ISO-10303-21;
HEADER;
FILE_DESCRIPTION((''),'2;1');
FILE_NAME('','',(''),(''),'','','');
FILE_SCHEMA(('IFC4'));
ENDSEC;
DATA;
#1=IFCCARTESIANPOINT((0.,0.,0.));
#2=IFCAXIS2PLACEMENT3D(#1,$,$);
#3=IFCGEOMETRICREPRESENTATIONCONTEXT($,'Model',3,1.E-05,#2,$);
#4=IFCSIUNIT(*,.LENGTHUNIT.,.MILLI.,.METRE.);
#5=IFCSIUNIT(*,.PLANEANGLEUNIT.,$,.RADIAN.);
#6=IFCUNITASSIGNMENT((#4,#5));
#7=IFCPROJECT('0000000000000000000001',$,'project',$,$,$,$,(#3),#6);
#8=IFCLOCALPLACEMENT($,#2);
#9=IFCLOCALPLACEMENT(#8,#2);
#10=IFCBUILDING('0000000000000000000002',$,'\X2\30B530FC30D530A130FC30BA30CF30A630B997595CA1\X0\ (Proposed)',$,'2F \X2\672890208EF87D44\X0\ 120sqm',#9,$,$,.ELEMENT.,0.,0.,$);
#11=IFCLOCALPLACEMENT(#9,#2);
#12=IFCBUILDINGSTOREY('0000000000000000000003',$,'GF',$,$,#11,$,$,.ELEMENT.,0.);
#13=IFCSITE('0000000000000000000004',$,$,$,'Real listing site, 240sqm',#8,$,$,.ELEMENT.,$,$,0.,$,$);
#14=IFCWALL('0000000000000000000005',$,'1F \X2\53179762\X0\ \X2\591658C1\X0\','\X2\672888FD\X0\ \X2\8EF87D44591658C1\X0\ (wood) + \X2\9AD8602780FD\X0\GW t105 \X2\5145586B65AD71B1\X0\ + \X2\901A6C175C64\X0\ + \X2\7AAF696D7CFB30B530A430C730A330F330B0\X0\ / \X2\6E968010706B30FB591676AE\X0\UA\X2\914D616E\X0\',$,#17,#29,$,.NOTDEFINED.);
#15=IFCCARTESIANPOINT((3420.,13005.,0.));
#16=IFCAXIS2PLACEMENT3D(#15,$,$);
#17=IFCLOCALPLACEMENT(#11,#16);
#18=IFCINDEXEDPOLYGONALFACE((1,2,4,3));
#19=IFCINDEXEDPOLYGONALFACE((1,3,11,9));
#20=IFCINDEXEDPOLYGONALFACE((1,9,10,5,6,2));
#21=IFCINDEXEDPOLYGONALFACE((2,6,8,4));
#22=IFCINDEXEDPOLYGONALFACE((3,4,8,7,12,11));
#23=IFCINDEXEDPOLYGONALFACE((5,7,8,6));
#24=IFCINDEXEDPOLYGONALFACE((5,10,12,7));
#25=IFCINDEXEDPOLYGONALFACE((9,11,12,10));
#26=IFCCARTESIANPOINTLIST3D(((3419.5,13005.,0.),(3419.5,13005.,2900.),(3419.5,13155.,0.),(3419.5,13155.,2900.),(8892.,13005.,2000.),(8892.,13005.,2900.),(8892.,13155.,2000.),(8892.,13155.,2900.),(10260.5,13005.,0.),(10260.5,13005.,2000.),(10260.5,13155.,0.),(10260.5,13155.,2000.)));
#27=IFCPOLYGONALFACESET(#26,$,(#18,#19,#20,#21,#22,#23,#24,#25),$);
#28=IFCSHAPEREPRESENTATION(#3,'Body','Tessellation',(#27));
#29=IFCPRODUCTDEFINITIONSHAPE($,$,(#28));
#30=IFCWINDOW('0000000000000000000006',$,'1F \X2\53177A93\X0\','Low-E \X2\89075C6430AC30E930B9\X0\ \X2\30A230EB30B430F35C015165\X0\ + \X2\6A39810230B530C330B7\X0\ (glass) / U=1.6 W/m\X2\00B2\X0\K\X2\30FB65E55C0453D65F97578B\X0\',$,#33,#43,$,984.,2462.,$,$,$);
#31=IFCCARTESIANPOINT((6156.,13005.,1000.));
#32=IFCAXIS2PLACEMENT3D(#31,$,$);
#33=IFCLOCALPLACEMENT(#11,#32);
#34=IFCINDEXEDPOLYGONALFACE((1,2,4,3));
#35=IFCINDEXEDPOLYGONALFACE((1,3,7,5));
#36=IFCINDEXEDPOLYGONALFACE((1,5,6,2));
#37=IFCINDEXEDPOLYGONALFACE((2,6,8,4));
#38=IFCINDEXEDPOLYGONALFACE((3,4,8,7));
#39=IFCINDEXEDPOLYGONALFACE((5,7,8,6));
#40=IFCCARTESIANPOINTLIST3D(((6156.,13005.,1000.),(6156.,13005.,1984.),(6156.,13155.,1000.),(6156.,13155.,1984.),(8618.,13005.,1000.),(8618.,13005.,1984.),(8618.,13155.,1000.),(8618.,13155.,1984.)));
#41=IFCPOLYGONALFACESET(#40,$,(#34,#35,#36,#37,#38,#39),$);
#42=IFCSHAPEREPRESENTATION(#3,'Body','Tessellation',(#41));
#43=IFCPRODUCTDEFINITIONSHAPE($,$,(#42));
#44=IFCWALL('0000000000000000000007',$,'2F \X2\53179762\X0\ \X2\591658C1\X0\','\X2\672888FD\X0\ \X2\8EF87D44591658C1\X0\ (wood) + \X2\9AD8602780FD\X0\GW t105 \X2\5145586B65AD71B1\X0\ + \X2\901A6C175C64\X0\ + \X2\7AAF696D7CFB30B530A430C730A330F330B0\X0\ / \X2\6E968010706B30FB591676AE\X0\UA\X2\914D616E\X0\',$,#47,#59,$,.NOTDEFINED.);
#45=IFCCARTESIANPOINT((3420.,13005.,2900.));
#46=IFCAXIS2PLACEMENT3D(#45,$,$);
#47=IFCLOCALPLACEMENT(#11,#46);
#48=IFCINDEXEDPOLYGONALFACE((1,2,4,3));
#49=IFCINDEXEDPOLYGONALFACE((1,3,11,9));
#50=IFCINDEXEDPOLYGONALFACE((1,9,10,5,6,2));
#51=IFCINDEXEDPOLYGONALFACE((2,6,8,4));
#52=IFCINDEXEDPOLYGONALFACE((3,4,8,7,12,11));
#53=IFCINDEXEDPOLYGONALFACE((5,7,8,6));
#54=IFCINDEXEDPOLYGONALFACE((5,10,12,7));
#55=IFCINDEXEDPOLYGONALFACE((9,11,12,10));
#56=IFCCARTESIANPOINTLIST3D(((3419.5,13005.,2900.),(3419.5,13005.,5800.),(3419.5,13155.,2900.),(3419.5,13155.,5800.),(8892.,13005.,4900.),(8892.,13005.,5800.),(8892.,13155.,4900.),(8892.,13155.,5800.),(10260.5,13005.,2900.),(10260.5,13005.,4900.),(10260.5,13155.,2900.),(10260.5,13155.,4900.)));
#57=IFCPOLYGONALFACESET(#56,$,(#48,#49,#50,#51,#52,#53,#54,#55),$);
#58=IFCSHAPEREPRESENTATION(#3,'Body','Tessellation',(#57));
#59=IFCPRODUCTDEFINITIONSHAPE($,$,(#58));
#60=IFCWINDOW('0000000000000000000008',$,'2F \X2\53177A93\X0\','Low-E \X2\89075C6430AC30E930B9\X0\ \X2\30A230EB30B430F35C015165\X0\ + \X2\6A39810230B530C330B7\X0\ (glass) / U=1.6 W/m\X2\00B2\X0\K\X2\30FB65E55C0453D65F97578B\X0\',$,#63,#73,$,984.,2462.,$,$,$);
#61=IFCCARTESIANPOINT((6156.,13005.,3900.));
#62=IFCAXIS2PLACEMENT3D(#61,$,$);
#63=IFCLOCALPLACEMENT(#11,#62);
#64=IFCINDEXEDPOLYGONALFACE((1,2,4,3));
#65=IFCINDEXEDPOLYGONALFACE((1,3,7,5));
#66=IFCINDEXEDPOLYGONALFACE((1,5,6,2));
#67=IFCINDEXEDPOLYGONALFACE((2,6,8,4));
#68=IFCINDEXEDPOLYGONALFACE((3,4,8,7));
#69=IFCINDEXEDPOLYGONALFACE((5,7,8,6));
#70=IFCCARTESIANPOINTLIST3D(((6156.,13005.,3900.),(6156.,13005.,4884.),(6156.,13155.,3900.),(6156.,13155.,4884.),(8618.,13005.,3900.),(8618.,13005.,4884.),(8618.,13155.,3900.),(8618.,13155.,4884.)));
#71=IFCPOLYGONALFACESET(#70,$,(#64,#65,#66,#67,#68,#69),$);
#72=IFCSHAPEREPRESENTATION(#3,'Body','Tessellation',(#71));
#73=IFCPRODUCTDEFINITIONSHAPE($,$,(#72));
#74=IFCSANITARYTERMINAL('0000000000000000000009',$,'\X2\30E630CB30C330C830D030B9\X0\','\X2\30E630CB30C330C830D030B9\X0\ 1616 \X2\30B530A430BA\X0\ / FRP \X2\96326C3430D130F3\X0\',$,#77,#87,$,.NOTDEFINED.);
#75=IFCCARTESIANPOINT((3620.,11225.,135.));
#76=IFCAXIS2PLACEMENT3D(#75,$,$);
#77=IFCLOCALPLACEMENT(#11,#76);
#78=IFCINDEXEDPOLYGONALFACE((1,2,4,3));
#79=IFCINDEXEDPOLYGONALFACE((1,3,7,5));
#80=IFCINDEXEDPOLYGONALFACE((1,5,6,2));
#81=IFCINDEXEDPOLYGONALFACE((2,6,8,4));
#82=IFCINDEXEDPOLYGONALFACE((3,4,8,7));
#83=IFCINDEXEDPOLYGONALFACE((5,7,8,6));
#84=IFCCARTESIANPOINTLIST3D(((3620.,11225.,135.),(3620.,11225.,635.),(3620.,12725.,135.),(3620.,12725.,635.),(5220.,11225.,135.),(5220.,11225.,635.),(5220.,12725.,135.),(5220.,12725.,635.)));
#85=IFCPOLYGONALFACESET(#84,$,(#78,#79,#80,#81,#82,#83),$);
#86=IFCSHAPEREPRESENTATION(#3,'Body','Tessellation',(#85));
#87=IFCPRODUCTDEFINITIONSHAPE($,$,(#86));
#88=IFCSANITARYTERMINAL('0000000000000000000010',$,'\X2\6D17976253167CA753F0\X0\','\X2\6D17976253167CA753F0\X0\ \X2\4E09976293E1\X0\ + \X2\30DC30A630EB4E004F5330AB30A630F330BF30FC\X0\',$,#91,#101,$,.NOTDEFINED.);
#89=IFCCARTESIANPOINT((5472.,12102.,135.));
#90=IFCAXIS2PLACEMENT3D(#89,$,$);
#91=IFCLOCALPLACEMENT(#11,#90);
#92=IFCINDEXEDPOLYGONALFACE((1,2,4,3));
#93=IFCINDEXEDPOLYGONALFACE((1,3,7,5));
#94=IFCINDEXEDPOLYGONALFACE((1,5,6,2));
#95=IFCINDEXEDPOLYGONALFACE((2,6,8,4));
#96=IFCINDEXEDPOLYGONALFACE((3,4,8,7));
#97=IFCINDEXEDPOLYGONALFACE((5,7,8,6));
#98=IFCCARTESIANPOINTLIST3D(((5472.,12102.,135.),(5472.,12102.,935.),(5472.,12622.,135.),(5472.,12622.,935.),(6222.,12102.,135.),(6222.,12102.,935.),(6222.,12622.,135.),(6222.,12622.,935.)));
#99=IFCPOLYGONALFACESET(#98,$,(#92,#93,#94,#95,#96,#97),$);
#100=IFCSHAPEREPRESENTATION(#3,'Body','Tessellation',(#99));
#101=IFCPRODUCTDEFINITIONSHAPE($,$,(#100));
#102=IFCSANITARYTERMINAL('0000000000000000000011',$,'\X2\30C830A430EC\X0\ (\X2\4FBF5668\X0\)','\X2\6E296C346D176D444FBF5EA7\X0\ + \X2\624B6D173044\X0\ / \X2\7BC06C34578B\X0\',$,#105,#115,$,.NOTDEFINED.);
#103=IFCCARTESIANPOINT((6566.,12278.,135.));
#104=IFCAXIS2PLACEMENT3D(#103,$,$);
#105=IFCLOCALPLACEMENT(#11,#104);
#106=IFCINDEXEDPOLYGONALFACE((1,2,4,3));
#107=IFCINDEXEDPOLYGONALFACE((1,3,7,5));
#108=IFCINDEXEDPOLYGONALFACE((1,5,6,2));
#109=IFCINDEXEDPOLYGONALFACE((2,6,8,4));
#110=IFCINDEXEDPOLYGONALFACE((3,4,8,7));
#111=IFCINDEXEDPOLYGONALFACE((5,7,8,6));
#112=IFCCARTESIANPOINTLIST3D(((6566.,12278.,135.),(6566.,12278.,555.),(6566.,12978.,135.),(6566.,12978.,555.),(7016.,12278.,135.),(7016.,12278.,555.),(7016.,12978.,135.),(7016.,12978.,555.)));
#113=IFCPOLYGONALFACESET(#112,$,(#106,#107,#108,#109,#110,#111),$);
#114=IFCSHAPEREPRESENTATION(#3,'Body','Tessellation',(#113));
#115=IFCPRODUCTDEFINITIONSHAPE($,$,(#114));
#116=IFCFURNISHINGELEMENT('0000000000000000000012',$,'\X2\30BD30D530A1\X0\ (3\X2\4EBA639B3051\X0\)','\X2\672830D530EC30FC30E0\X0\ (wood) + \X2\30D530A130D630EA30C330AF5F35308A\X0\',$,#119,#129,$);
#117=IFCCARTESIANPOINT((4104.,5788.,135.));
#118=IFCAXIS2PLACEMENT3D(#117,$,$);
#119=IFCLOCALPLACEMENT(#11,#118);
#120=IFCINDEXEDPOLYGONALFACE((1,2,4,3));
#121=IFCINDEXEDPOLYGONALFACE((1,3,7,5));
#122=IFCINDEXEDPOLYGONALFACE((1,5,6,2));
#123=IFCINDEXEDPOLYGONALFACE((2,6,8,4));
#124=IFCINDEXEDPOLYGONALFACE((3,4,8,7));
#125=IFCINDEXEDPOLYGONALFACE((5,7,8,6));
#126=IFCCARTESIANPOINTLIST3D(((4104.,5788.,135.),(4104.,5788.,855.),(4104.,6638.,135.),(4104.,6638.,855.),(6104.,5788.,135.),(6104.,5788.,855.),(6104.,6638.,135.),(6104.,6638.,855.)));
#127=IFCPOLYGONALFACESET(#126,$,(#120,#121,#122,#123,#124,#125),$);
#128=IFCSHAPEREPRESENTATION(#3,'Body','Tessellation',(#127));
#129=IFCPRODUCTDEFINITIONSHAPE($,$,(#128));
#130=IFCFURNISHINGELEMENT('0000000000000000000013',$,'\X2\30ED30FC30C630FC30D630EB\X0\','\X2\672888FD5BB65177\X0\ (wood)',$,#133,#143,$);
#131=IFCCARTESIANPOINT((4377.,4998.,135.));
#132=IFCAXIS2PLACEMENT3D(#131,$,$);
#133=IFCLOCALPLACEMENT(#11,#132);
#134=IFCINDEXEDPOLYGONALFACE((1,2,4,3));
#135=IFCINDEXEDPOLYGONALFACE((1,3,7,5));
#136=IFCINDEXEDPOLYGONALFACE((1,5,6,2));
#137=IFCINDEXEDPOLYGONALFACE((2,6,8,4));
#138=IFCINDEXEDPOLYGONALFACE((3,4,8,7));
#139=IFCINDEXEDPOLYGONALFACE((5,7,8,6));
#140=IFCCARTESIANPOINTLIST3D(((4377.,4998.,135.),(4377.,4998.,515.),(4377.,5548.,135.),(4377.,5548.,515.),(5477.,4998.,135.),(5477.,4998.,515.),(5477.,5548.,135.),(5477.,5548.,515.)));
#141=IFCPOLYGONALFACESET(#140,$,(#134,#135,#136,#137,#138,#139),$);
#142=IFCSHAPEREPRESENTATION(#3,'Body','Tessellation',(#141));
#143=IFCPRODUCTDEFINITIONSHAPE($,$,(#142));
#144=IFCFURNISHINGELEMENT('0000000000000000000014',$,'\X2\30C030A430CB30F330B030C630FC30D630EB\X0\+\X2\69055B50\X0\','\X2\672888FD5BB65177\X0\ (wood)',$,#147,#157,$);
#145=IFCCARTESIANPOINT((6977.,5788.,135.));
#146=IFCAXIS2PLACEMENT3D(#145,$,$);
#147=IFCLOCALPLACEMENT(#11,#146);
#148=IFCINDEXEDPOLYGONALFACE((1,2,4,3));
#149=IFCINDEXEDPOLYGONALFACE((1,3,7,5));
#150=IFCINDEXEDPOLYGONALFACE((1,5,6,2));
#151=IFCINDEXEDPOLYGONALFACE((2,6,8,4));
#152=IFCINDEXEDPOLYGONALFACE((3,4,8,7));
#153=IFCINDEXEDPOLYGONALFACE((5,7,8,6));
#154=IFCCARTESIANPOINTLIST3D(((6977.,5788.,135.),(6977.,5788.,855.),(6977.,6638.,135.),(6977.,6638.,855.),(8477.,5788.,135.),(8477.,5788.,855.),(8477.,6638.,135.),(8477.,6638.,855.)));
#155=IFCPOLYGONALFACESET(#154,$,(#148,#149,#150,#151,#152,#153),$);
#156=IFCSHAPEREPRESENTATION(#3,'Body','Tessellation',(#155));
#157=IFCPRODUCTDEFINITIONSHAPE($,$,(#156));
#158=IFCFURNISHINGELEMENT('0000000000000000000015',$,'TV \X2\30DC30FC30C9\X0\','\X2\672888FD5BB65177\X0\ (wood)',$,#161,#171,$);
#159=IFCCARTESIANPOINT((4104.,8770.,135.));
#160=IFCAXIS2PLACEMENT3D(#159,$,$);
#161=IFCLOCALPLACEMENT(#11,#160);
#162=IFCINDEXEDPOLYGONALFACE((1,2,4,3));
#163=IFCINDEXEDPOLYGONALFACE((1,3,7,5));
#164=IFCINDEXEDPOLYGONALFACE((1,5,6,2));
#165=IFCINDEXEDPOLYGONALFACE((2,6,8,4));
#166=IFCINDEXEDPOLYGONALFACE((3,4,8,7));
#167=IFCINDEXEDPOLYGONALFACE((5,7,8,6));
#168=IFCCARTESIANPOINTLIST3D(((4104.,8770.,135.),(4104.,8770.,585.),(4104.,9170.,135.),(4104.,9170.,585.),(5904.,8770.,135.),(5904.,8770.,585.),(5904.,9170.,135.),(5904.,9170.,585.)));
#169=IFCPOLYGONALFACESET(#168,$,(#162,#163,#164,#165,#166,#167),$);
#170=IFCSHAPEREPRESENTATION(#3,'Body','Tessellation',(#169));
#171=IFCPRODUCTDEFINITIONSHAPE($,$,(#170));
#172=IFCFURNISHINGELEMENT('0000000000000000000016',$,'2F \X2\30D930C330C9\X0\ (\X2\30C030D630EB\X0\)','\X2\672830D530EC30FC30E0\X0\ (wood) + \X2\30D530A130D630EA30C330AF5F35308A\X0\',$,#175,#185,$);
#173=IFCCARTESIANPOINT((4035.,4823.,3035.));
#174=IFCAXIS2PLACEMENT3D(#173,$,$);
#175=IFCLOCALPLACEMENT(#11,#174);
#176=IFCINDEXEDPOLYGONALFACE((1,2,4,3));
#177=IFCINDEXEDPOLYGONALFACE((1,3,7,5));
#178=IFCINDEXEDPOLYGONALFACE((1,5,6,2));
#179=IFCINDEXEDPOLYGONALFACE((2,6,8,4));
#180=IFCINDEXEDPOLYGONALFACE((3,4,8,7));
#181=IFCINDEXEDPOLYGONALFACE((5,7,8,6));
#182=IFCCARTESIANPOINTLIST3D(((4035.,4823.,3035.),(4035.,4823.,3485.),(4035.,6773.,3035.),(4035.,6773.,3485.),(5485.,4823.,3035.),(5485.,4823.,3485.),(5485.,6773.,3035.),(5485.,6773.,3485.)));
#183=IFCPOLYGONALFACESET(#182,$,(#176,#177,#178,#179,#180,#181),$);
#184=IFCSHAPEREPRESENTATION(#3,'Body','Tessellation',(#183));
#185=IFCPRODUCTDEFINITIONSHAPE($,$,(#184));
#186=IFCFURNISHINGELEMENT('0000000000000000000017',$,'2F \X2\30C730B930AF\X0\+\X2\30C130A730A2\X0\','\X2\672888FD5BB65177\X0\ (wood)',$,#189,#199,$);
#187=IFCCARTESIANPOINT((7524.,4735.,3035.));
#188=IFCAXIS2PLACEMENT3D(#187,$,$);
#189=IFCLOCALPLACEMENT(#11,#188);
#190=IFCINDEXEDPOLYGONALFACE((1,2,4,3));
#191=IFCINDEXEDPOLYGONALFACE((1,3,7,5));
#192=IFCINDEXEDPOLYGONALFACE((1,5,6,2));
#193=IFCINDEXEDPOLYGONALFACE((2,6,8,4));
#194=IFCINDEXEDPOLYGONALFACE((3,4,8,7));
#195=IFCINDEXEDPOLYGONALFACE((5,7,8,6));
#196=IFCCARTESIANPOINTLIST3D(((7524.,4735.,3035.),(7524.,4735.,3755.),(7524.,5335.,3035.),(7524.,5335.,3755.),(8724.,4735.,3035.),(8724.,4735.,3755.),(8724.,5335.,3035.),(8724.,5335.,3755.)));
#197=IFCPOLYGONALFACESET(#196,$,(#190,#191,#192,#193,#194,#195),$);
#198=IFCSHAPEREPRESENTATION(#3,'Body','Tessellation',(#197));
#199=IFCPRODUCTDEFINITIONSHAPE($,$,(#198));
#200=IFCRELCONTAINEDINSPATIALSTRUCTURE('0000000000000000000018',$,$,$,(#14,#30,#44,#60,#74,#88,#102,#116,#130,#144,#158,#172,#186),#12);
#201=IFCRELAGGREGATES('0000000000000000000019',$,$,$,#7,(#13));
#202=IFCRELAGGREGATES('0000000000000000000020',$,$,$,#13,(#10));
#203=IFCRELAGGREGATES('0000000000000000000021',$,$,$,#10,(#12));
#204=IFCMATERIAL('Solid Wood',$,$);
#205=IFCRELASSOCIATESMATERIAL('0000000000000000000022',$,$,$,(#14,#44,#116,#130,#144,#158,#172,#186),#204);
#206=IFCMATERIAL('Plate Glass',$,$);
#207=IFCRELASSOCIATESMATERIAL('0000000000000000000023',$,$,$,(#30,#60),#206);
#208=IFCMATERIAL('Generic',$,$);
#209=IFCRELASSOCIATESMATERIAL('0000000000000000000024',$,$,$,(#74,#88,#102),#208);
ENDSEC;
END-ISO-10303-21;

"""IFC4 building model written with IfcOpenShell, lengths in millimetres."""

from ifc_helpers import new_model, si_unit, frame, frame_2d, origin, place, context, project, spatial, rectangle, extrude, material, element, fill, save


model = new_model("IFC4")

# Units and contexts
model_context = context("Model", 3, precision=1e-05, world=origin())
ifc_project = project(units=[si_unit("LENGTHUNIT", "METRE", prefix="MILLI"), si_unit("PLANEANGLEUNIT", "RADIAN")], contexts=[model_context])

# Site, building, storey
site_placement = place(None, origin())
site = spatial("IfcSite", under=ifc_project, at=site_placement, ObjectType="Real listing site, 240sqm", CompositionType="ELEMENT", RefElevation=0.0)
building_placement = place(site_placement, origin())
building = spatial("IfcBuilding", under=site, at=building_placement, Name="サーファーズハウス静岡 (Proposed)", ObjectType="2F 木造軸組 120sqm", CompositionType="ELEMENT", ElevationOfRefHeight=0.0, ElevationOfTerrain=0.0)
storey_placement = place(building_placement, origin())
storey = spatial("IfcBuildingStorey", under=building, at=storey_placement, Name="GF", CompositionType="ELEMENT", Elevation=0.0)

# Wall, opening, window
ifc_material_1 = material(Name="Solid Wood")
wall_1_placement = place(storey_placement, frame((3420.0, 13005.0, 0.0)))
wall_1 = element("IfcWall", 1, at=wall_1_placement, inside=storey, material=ifc_material_1, Name="1F 北面 外壁", Description="木製 軸組外壁 (wood) + 高性能GW t105 充填断熱 + 通気層 + 窯業系サイディング / 準耐火・外皮UA配慮", PredefinedType="NOTDEFINED", context=model_context, shape_type="SweptSolid", body=[
    extrude(rectangle(XDim=6841.0, YDim=150.0, at=frame_2d((3420.0, 75.0))), frame((3420.0, 13005.0, 0.0)), (0.0, 0.0, 1.0), 2900.0),
])
opening_1_placement = place(storey_placement, frame((6156.0, 13005.0, 1000.0)))
opening_1 = element("IfcOpeningElement", 2, at=opening_1_placement, cuts=wall_1, PredefinedType="NOTDEFINED", context=model_context, shape_type="SweptSolid", body=[
    extrude(rectangle(XDim=2462.0, YDim=150.0, at=frame_2d((1231.0, 75.0))), frame((6156.0, 13005.0, 1000.0)), (0.0, 0.0, 1.0), 984.0),
])
ifc_material_2 = material(Name="Plate Glass")
window_1_placement = place(storey_placement, frame((6156.0, 13005.0, 1000.0)))
window_1 = element("IfcWindow", 3, at=window_1_placement, inside=storey, material=ifc_material_2, Name="1F 北窓", Description="Low-E 複層ガラス アルゴン封入 + 樹脂サッシ (glass) / U=1.6 W/m²K・日射取得型", OverallHeight=984.0, OverallWidth=2462.0, context=model_context, shape_type="SweptSolid", body=[
    extrude(rectangle(XDim=2462.0, YDim=150.0, at=frame_2d((1231.0, 75.0))), frame((6156.0, 13005.0, 1000.0)), (0.0, 0.0, 1.0), 984.0),
])
fill(opening_1, window_1)

# Wall, opening, window
wall_2_placement = place(storey_placement, frame((3420.0, 13005.0, 2900.0)))
wall_2 = element("IfcWall", 4, at=wall_2_placement, inside=storey, material=ifc_material_1, Name="2F 北面 外壁", Description="木製 軸組外壁 (wood) + 高性能GW t105 充填断熱 + 通気層 + 窯業系サイディング / 準耐火・外皮UA配慮", PredefinedType="NOTDEFINED", context=model_context, shape_type="SweptSolid", body=[
    extrude(rectangle(XDim=6841.0, YDim=150.0, at=frame_2d((3420.0, 75.0))), frame((3420.0, 13005.0, 2900.0)), (0.0, 0.0, 1.0), 2900.0),
])
opening_2_placement = place(storey_placement, frame((6156.0, 13005.0, 3900.0)))
opening_2 = element("IfcOpeningElement", 5, at=opening_2_placement, cuts=wall_2, PredefinedType="NOTDEFINED", context=model_context, shape_type="SweptSolid", body=[
    extrude(rectangle(XDim=2462.0, YDim=150.0, at=frame_2d((1231.0, 75.0))), frame((6156.0, 13005.0, 3900.0)), (0.0, 0.0, 1.0), 984.0),
])
window_2_placement = place(storey_placement, frame((6156.0, 13005.0, 3900.0)))
window_2 = element("IfcWindow", 6, at=window_2_placement, inside=storey, material=ifc_material_2, Name="2F 北窓", Description="Low-E 複層ガラス アルゴン封入 + 樹脂サッシ (glass) / U=1.6 W/m²K・日射取得型", OverallHeight=984.0, OverallWidth=2462.0, context=model_context, shape_type="SweptSolid", body=[
    extrude(rectangle(XDim=2462.0, YDim=150.0, at=frame_2d((1231.0, 75.0))), frame((6156.0, 13005.0, 3900.0)), (0.0, 0.0, 1.0), 984.0),
])
fill(opening_2, window_2)

# Sanitary terminals
ifc_material_3 = material(Name="Generic")
sanitary_terminal_1_placement = place(storey_placement, frame((3620.0, 11225.0, 135.0)))
element("IfcSanitaryTerminal", 7, at=sanitary_terminal_1_placement, inside=storey, material=ifc_material_3, Name="ユニットバス", Description="ユニットバス 1616 サイズ / FRP 防水パン", PredefinedType="NOTDEFINED", context=model_context, shape_type="SweptSolid", body=[
    extrude(rectangle(XDim=1600.0, YDim=1500.0, at=frame_2d((800.0, 750.0))), frame((3620.0, 11225.0, 135.0)), (0.0, 0.0, 1.0), 500.0),
])
sanitary_terminal_2_placement = place(storey_placement, frame((5472.0, 12102.0, 135.0)))
element("IfcSanitaryTerminal", 8, at=sanitary_terminal_2_placement, inside=storey, material=ifc_material_3, Name="洗面化粧台", Description="洗面化粧台 三面鏡 + ボウル一体カウンター", PredefinedType="NOTDEFINED", context=model_context, shape_type="SweptSolid", body=[
    extrude(rectangle(XDim=750.0, YDim=520.0, at=frame_2d((375.0, 260.0))), frame((5472.0, 12102.0, 135.0)), (0.0, 0.0, 1.0), 800.0),
])
sanitary_terminal_3_placement = place(storey_placement, frame((6566.0, 12278.0, 135.0)))
element("IfcSanitaryTerminal", 9, at=sanitary_terminal_3_placement, inside=storey, material=ifc_material_3, Name="トイレ (便器)", Description="温水洗浄便座 + 手洗い / 節水型", PredefinedType="NOTDEFINED", context=model_context, shape_type="SweptSolid", body=[
    extrude(rectangle(XDim=450.0, YDim=700.0, at=frame_2d((225.0, 350.0))), frame((6566.0, 12278.0, 135.0)), (0.0, 0.0, 1.0), 420.0),
])

# Furnishing elements
furnishing_1_placement = place(storey_placement, frame((4104.0, 5788.0, 135.0)))
element("IfcFurnishingElement", 10, at=furnishing_1_placement, inside=storey, material=ifc_material_1, Name="ソファ (3人掛け)", Description="木フレーム (wood) + ファブリック張り", context=model_context, shape_type="SweptSolid", body=[
    extrude(rectangle(XDim=2000.0, YDim=850.0, at=frame_2d((1000.0, 425.0))), frame((4104.0, 5788.0, 135.0)), (0.0, 0.0, 1.0), 720.0),
])
furnishing_2_placement = place(storey_placement, frame((4377.0, 4998.0, 135.0)))
element("IfcFurnishingElement", 11, at=furnishing_2_placement, inside=storey, material=ifc_material_1, Name="ローテーブル", Description="木製家具 (wood)", context=model_context, shape_type="SweptSolid", body=[
    extrude(rectangle(XDim=1100.0, YDim=550.0, at=frame_2d((550.0, 275.0))), frame((4377.0, 4998.0, 135.0)), (0.0, 0.0, 1.0), 380.0),
])
furnishing_3_placement = place(storey_placement, frame((6977.0, 5788.0, 135.0)))
element("IfcFurnishingElement", 12, at=furnishing_3_placement, inside=storey, material=ifc_material_1, Name="ダイニングテーブル+椅子", Description="木製家具 (wood)", context=model_context, shape_type="SweptSolid", body=[
    extrude(rectangle(XDim=1500.0, YDim=850.0, at=frame_2d((750.0, 425.0))), frame((6977.0, 5788.0, 135.0)), (0.0, 0.0, 1.0), 720.0),
])
furnishing_4_placement = place(storey_placement, frame((4104.0, 8770.0, 135.0)))
element("IfcFurnishingElement", 13, at=furnishing_4_placement, inside=storey, material=ifc_material_1, Name="TV ボード", Description="木製家具 (wood)", context=model_context, shape_type="SweptSolid", body=[
    extrude(rectangle(XDim=1800.0, YDim=400.0, at=frame_2d((900.0, 200.0))), frame((4104.0, 8770.0, 135.0)), (0.0, 0.0, 1.0), 450.0),
])
furnishing_5_placement = place(storey_placement, frame((4035.0, 4823.0, 3035.0)))
element("IfcFurnishingElement", 14, at=furnishing_5_placement, inside=storey, material=ifc_material_1, Name="2F ベッド (ダブル)", Description="木フレーム (wood) + ファブリック張り", context=model_context, shape_type="SweptSolid", body=[
    extrude(rectangle(XDim=1450.0, YDim=1950.0, at=frame_2d((725.0, 975.0))), frame((4035.0, 4823.0, 3035.0)), (0.0, 0.0, 1.0), 450.0),
])
furnishing_6_placement = place(storey_placement, frame((7524.0, 4735.0, 3035.0)))
element("IfcFurnishingElement", 15, at=furnishing_6_placement, inside=storey, material=ifc_material_1, Name="2F デスク+チェア", Description="木製家具 (wood)", context=model_context, shape_type="SweptSolid", body=[
    extrude(rectangle(XDim=1200.0, YDim=600.0, at=frame_2d((600.0, 300.0))), frame((7524.0, 4735.0, 3035.0)), (0.0, 0.0, 1.0), 720.0),
])

save(model, "model.ifc")
